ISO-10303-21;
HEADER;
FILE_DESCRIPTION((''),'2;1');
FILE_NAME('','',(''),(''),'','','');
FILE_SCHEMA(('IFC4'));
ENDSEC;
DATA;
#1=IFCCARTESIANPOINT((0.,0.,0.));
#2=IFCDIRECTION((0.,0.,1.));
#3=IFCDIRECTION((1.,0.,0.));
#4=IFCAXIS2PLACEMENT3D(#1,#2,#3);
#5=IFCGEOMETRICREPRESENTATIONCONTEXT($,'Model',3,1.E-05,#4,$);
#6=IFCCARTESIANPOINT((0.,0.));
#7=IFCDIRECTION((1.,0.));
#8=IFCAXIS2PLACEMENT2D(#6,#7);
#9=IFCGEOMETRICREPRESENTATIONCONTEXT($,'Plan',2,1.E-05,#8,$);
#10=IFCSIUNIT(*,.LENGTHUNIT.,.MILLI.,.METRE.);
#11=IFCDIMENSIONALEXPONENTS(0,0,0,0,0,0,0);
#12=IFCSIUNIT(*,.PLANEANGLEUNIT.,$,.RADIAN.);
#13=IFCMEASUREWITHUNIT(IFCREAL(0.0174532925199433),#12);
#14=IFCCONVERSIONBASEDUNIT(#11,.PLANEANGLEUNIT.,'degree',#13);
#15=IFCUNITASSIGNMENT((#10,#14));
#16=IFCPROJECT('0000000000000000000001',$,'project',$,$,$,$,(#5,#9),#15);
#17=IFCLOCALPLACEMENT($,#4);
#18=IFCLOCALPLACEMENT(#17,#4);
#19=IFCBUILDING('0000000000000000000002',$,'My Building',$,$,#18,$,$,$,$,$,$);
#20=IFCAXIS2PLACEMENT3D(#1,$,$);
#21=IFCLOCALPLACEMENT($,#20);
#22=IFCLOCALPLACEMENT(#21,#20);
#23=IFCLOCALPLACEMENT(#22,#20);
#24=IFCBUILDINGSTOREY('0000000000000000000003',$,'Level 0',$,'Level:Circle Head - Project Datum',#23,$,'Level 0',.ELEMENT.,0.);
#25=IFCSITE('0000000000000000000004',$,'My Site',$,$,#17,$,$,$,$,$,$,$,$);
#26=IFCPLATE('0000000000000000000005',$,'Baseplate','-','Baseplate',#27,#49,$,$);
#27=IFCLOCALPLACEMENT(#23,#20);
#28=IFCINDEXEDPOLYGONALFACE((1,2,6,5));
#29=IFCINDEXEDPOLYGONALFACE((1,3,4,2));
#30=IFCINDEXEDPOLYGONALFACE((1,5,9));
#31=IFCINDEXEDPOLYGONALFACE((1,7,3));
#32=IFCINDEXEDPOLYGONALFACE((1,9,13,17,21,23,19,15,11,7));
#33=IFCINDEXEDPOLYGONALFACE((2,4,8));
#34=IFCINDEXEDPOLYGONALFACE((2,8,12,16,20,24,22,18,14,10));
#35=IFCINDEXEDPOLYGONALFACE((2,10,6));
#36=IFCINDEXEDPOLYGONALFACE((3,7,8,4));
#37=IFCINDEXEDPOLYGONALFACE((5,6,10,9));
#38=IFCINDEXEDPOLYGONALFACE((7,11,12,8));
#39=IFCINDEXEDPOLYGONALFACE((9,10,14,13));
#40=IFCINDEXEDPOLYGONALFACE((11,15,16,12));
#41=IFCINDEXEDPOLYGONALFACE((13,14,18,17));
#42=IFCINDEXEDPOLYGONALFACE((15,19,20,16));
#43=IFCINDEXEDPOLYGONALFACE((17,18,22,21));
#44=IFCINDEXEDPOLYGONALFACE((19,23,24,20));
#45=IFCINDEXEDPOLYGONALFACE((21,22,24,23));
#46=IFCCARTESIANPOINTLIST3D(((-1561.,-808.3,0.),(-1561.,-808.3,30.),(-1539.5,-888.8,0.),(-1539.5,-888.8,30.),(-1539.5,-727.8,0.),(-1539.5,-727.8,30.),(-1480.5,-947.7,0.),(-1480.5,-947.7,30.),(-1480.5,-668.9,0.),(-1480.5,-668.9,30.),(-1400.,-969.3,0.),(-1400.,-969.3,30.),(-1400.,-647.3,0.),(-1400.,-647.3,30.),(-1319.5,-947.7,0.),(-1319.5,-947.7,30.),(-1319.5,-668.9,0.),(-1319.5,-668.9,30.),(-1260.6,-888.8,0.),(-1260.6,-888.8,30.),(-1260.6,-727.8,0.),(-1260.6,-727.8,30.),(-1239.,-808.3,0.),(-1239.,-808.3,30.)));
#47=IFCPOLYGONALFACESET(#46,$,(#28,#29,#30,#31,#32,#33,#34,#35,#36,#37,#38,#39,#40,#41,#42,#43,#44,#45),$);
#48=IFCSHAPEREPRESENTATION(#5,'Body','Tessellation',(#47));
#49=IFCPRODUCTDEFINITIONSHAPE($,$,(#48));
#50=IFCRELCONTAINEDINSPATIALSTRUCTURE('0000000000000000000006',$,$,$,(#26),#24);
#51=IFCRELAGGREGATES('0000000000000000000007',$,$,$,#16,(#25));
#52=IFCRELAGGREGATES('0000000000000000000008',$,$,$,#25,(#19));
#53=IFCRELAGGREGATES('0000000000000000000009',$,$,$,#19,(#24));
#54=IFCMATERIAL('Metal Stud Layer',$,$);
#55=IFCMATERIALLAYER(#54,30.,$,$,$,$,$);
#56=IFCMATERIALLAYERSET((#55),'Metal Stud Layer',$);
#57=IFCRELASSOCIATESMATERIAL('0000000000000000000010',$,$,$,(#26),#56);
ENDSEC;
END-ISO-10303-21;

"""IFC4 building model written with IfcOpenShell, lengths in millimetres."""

from ifc_helpers import new_model, entity, si_unit, converted_unit, point, frame, frame_2d, origin, origin_with_axes, origin_2d_with_axis, place, context, project, spatial, polyline, circle_curve, line_curve, trimmed, segment, composite_curve, outline, extrude, material, layer, layer_set, element, save


model = new_model("IFC4")

# Units and contexts
model_context = context("Model", 3, precision=1e-05, world=origin_with_axes())
plan_context = context("Plan", 2, precision=1e-05, world=origin_2d_with_axis())
ifc_project = project(units=[si_unit("LENGTHUNIT", "METRE", prefix="MILLI"), converted_unit("PLANEANGLEUNIT", "degree", entity("IfcReal", 0.0174532925199433), si_unit("PLANEANGLEUNIT", "RADIAN"), dimensions=[0, 0, 0, 0, 0, 0, 0])], contexts=[model_context, plan_context])

# Site, building, storey
site_placement = place(None, origin_with_axes())
site = spatial("IfcSite", under=ifc_project, at=site_placement, Name="My Site")
building_placement = place(site_placement, origin_with_axes())
building = spatial("IfcBuilding", under=site, at=building_placement, Name="My Building")
placement_1 = place(None, origin())
placement_2 = place(placement_1, origin())
storey_placement = place(placement_2, origin())
storey = spatial("IfcBuildingStorey", under=building, at=storey_placement, Name="Level 0", ObjectType="Level:Circle Head - Project Datum", LongName="Level 0", CompositionType="ELEMENT", Elevation=0.0)

# Shared definitions
ifc_material_1 = material(Name="Metal Stud Layer")

# Plate, openings
ifc_layer_1 = layer(ifc_material_1, 30.0)
ifc_layer_set_1 = layer_set([ifc_layer_1], Name="Metal Stud Layer")
plate_1_placement = place(storey_placement, frame((-1319.5, -947.7, 30.0), z_axis=(0.0, 0.0, -1.0), x_axis=(-0.866025, -0.5, 0.0)))
plate_1 = element("IfcPlate", 1, at=plate_1_placement, inside=storey, material=ifc_layer_set_1, Name="Baseplate", Description="-", ObjectType="Baseplate", context=model_context, shape_type="SweptSolid", body=[
    extrude(outline(polyline([(161.0, 0.0), (161.0, 322.0), (-161.0, 322.0), (-161.0, 0.0), (161.0, 0.0)])), origin_with_axes(), (0.0, 0.0, 1.0), 30.0),
])
opening_1_placement = place(plate_1_placement, frame((0.0, 0.0, 0.0), z_axis=(0.0, 0.0, 1.0), x_axis=(1.0, 0.0, 0.0)))
element("IfcOpeningElement", 2, at=opening_1_placement, cuts=plate_1, ObjectType="Opening", context=model_context, shape_type="SweptSolid", body=[
    extrude(outline(composite_curve([segment(trimmed(line_curve((-161.0, 0.0), (1.0, 0.0), 161.0), [point((-161.0, 0.0))], [point((0.0, 0.0))], True, "CARTESIAN"), True, "CONTINUOUS"), segment(trimmed(circle_curve(frame_2d((0.0, 161.0), x_axis=(-1.0, 0.0)), 161.0), [point((0.0, 0.0))], [point((-161.0, 161.0))], False, "CARTESIAN"), True, "CONTINUOUS"), segment(trimmed(line_curve((-161.0, 161.0), (0.0, -1.0), 161.0), [point((-161.0, 161.0))], [point((-161.0, 0.0))], True, "CARTESIAN"), True, "CONTINUOUS")], self_intersect=False)), origin(), (0.0, 0.0, 1.0), 30.0),
])
opening_2_placement = place(plate_1_placement, frame((0.0, 0.0, 0.0), z_axis=(0.0, 0.0, 1.0), x_axis=(1.0, 0.0, 0.0)))
element("IfcOpeningElement", 3, at=opening_2_placement, cuts=plate_1, ObjectType="Opening", context=model_context, shape_type="SweptSolid", body=[
    extrude(outline(composite_curve([segment(trimmed(line_curve((-161.0, 322.0), (0.0, -1.0), 161.0), [point((-161.0, 322.0))], [point((-161.0, 161.0))], True, "CARTESIAN"), True, "CONTINUOUS"), segment(trimmed(circle_curve(frame_2d((0.0, 161.0), x_axis=(-1.0, 0.0)), 161.0), [point((-161.0, 161.0))], [point((0.0, 322.0))], False, "CARTESIAN"), True, "CONTINUOUS"), segment(trimmed(line_curve((0.0, 322.0), (-1.0, 0.0), 161.0), [point((0.0, 322.0))], [point((-161.0, 322.0))], True, "CARTESIAN"), True, "CONTINUOUS")], self_intersect=False)), origin(), (0.0, 0.0, 1.0), 30.0),
])
opening_3_placement = place(plate_1_placement, frame((0.0, 0.0, 0.0), z_axis=(0.0, 0.0, 1.0), x_axis=(1.0, 0.0, 0.0)))
element("IfcOpeningElement", 4, at=opening_3_placement, cuts=plate_1, ObjectType="Opening", context=model_context, shape_type="SweptSolid", body=[
    extrude(outline(composite_curve([segment(trimmed(line_curve((161.0, 0.0), (0.0, 1.0), 161.0), [point((161.0, 0.0))], [point((161.0, 161.0))], True, "CARTESIAN"), True, "CONTINUOUS"), segment(trimmed(circle_curve(frame_2d((0.0, 161.0), x_axis=(-1.0, 0.0)), 161.0), [point((161.0, 161.0))], [point((0.0, 0.0))], False, "CARTESIAN"), True, "CONTINUOUS"), segment(trimmed(line_curve((0.0, 0.0), (1.0, 0.0), 161.0), [point((0.0, 0.0))], [point((161.0, 0.0))], True, "CARTESIAN"), True, "CONTINUOUS")], self_intersect=False)), origin(), (0.0, 0.0, 1.0), 30.0),
])
opening_4_placement = place(plate_1_placement, frame((0.0, 0.0, 0.0), z_axis=(0.0, 0.0, 1.0), x_axis=(1.0, 0.0, 0.0)))
element("IfcOpeningElement", 5, at=opening_4_placement, cuts=plate_1, ObjectType="Opening", context=model_context, shape_type="SweptSolid", body=[
    extrude(outline(composite_curve([segment(trimmed(line_curve((161.0, 322.0), (-1.0, 0.0), 161.0), [point((161.0, 322.0))], [point((0.0, 322.0))], True, "CARTESIAN"), True, "CONTINUOUS"), segment(trimmed(circle_curve(frame_2d((0.0, 161.0), x_axis=(-1.0, 0.0)), 161.0), [point((0.0, 322.0))], [point((161.0, 161.0))], False, "CARTESIAN"), True, "CONTINUOUS"), segment(trimmed(line_curve((161.0, 161.0), (0.0, 1.0), 161.0), [point((161.0, 161.0))], [point((161.0, 322.0))], True, "CARTESIAN"), True, "CONTINUOUS")], self_intersect=False)), origin(), (0.0, 0.0, 1.0), 30.0),
])

save(model, "model.ifc")
